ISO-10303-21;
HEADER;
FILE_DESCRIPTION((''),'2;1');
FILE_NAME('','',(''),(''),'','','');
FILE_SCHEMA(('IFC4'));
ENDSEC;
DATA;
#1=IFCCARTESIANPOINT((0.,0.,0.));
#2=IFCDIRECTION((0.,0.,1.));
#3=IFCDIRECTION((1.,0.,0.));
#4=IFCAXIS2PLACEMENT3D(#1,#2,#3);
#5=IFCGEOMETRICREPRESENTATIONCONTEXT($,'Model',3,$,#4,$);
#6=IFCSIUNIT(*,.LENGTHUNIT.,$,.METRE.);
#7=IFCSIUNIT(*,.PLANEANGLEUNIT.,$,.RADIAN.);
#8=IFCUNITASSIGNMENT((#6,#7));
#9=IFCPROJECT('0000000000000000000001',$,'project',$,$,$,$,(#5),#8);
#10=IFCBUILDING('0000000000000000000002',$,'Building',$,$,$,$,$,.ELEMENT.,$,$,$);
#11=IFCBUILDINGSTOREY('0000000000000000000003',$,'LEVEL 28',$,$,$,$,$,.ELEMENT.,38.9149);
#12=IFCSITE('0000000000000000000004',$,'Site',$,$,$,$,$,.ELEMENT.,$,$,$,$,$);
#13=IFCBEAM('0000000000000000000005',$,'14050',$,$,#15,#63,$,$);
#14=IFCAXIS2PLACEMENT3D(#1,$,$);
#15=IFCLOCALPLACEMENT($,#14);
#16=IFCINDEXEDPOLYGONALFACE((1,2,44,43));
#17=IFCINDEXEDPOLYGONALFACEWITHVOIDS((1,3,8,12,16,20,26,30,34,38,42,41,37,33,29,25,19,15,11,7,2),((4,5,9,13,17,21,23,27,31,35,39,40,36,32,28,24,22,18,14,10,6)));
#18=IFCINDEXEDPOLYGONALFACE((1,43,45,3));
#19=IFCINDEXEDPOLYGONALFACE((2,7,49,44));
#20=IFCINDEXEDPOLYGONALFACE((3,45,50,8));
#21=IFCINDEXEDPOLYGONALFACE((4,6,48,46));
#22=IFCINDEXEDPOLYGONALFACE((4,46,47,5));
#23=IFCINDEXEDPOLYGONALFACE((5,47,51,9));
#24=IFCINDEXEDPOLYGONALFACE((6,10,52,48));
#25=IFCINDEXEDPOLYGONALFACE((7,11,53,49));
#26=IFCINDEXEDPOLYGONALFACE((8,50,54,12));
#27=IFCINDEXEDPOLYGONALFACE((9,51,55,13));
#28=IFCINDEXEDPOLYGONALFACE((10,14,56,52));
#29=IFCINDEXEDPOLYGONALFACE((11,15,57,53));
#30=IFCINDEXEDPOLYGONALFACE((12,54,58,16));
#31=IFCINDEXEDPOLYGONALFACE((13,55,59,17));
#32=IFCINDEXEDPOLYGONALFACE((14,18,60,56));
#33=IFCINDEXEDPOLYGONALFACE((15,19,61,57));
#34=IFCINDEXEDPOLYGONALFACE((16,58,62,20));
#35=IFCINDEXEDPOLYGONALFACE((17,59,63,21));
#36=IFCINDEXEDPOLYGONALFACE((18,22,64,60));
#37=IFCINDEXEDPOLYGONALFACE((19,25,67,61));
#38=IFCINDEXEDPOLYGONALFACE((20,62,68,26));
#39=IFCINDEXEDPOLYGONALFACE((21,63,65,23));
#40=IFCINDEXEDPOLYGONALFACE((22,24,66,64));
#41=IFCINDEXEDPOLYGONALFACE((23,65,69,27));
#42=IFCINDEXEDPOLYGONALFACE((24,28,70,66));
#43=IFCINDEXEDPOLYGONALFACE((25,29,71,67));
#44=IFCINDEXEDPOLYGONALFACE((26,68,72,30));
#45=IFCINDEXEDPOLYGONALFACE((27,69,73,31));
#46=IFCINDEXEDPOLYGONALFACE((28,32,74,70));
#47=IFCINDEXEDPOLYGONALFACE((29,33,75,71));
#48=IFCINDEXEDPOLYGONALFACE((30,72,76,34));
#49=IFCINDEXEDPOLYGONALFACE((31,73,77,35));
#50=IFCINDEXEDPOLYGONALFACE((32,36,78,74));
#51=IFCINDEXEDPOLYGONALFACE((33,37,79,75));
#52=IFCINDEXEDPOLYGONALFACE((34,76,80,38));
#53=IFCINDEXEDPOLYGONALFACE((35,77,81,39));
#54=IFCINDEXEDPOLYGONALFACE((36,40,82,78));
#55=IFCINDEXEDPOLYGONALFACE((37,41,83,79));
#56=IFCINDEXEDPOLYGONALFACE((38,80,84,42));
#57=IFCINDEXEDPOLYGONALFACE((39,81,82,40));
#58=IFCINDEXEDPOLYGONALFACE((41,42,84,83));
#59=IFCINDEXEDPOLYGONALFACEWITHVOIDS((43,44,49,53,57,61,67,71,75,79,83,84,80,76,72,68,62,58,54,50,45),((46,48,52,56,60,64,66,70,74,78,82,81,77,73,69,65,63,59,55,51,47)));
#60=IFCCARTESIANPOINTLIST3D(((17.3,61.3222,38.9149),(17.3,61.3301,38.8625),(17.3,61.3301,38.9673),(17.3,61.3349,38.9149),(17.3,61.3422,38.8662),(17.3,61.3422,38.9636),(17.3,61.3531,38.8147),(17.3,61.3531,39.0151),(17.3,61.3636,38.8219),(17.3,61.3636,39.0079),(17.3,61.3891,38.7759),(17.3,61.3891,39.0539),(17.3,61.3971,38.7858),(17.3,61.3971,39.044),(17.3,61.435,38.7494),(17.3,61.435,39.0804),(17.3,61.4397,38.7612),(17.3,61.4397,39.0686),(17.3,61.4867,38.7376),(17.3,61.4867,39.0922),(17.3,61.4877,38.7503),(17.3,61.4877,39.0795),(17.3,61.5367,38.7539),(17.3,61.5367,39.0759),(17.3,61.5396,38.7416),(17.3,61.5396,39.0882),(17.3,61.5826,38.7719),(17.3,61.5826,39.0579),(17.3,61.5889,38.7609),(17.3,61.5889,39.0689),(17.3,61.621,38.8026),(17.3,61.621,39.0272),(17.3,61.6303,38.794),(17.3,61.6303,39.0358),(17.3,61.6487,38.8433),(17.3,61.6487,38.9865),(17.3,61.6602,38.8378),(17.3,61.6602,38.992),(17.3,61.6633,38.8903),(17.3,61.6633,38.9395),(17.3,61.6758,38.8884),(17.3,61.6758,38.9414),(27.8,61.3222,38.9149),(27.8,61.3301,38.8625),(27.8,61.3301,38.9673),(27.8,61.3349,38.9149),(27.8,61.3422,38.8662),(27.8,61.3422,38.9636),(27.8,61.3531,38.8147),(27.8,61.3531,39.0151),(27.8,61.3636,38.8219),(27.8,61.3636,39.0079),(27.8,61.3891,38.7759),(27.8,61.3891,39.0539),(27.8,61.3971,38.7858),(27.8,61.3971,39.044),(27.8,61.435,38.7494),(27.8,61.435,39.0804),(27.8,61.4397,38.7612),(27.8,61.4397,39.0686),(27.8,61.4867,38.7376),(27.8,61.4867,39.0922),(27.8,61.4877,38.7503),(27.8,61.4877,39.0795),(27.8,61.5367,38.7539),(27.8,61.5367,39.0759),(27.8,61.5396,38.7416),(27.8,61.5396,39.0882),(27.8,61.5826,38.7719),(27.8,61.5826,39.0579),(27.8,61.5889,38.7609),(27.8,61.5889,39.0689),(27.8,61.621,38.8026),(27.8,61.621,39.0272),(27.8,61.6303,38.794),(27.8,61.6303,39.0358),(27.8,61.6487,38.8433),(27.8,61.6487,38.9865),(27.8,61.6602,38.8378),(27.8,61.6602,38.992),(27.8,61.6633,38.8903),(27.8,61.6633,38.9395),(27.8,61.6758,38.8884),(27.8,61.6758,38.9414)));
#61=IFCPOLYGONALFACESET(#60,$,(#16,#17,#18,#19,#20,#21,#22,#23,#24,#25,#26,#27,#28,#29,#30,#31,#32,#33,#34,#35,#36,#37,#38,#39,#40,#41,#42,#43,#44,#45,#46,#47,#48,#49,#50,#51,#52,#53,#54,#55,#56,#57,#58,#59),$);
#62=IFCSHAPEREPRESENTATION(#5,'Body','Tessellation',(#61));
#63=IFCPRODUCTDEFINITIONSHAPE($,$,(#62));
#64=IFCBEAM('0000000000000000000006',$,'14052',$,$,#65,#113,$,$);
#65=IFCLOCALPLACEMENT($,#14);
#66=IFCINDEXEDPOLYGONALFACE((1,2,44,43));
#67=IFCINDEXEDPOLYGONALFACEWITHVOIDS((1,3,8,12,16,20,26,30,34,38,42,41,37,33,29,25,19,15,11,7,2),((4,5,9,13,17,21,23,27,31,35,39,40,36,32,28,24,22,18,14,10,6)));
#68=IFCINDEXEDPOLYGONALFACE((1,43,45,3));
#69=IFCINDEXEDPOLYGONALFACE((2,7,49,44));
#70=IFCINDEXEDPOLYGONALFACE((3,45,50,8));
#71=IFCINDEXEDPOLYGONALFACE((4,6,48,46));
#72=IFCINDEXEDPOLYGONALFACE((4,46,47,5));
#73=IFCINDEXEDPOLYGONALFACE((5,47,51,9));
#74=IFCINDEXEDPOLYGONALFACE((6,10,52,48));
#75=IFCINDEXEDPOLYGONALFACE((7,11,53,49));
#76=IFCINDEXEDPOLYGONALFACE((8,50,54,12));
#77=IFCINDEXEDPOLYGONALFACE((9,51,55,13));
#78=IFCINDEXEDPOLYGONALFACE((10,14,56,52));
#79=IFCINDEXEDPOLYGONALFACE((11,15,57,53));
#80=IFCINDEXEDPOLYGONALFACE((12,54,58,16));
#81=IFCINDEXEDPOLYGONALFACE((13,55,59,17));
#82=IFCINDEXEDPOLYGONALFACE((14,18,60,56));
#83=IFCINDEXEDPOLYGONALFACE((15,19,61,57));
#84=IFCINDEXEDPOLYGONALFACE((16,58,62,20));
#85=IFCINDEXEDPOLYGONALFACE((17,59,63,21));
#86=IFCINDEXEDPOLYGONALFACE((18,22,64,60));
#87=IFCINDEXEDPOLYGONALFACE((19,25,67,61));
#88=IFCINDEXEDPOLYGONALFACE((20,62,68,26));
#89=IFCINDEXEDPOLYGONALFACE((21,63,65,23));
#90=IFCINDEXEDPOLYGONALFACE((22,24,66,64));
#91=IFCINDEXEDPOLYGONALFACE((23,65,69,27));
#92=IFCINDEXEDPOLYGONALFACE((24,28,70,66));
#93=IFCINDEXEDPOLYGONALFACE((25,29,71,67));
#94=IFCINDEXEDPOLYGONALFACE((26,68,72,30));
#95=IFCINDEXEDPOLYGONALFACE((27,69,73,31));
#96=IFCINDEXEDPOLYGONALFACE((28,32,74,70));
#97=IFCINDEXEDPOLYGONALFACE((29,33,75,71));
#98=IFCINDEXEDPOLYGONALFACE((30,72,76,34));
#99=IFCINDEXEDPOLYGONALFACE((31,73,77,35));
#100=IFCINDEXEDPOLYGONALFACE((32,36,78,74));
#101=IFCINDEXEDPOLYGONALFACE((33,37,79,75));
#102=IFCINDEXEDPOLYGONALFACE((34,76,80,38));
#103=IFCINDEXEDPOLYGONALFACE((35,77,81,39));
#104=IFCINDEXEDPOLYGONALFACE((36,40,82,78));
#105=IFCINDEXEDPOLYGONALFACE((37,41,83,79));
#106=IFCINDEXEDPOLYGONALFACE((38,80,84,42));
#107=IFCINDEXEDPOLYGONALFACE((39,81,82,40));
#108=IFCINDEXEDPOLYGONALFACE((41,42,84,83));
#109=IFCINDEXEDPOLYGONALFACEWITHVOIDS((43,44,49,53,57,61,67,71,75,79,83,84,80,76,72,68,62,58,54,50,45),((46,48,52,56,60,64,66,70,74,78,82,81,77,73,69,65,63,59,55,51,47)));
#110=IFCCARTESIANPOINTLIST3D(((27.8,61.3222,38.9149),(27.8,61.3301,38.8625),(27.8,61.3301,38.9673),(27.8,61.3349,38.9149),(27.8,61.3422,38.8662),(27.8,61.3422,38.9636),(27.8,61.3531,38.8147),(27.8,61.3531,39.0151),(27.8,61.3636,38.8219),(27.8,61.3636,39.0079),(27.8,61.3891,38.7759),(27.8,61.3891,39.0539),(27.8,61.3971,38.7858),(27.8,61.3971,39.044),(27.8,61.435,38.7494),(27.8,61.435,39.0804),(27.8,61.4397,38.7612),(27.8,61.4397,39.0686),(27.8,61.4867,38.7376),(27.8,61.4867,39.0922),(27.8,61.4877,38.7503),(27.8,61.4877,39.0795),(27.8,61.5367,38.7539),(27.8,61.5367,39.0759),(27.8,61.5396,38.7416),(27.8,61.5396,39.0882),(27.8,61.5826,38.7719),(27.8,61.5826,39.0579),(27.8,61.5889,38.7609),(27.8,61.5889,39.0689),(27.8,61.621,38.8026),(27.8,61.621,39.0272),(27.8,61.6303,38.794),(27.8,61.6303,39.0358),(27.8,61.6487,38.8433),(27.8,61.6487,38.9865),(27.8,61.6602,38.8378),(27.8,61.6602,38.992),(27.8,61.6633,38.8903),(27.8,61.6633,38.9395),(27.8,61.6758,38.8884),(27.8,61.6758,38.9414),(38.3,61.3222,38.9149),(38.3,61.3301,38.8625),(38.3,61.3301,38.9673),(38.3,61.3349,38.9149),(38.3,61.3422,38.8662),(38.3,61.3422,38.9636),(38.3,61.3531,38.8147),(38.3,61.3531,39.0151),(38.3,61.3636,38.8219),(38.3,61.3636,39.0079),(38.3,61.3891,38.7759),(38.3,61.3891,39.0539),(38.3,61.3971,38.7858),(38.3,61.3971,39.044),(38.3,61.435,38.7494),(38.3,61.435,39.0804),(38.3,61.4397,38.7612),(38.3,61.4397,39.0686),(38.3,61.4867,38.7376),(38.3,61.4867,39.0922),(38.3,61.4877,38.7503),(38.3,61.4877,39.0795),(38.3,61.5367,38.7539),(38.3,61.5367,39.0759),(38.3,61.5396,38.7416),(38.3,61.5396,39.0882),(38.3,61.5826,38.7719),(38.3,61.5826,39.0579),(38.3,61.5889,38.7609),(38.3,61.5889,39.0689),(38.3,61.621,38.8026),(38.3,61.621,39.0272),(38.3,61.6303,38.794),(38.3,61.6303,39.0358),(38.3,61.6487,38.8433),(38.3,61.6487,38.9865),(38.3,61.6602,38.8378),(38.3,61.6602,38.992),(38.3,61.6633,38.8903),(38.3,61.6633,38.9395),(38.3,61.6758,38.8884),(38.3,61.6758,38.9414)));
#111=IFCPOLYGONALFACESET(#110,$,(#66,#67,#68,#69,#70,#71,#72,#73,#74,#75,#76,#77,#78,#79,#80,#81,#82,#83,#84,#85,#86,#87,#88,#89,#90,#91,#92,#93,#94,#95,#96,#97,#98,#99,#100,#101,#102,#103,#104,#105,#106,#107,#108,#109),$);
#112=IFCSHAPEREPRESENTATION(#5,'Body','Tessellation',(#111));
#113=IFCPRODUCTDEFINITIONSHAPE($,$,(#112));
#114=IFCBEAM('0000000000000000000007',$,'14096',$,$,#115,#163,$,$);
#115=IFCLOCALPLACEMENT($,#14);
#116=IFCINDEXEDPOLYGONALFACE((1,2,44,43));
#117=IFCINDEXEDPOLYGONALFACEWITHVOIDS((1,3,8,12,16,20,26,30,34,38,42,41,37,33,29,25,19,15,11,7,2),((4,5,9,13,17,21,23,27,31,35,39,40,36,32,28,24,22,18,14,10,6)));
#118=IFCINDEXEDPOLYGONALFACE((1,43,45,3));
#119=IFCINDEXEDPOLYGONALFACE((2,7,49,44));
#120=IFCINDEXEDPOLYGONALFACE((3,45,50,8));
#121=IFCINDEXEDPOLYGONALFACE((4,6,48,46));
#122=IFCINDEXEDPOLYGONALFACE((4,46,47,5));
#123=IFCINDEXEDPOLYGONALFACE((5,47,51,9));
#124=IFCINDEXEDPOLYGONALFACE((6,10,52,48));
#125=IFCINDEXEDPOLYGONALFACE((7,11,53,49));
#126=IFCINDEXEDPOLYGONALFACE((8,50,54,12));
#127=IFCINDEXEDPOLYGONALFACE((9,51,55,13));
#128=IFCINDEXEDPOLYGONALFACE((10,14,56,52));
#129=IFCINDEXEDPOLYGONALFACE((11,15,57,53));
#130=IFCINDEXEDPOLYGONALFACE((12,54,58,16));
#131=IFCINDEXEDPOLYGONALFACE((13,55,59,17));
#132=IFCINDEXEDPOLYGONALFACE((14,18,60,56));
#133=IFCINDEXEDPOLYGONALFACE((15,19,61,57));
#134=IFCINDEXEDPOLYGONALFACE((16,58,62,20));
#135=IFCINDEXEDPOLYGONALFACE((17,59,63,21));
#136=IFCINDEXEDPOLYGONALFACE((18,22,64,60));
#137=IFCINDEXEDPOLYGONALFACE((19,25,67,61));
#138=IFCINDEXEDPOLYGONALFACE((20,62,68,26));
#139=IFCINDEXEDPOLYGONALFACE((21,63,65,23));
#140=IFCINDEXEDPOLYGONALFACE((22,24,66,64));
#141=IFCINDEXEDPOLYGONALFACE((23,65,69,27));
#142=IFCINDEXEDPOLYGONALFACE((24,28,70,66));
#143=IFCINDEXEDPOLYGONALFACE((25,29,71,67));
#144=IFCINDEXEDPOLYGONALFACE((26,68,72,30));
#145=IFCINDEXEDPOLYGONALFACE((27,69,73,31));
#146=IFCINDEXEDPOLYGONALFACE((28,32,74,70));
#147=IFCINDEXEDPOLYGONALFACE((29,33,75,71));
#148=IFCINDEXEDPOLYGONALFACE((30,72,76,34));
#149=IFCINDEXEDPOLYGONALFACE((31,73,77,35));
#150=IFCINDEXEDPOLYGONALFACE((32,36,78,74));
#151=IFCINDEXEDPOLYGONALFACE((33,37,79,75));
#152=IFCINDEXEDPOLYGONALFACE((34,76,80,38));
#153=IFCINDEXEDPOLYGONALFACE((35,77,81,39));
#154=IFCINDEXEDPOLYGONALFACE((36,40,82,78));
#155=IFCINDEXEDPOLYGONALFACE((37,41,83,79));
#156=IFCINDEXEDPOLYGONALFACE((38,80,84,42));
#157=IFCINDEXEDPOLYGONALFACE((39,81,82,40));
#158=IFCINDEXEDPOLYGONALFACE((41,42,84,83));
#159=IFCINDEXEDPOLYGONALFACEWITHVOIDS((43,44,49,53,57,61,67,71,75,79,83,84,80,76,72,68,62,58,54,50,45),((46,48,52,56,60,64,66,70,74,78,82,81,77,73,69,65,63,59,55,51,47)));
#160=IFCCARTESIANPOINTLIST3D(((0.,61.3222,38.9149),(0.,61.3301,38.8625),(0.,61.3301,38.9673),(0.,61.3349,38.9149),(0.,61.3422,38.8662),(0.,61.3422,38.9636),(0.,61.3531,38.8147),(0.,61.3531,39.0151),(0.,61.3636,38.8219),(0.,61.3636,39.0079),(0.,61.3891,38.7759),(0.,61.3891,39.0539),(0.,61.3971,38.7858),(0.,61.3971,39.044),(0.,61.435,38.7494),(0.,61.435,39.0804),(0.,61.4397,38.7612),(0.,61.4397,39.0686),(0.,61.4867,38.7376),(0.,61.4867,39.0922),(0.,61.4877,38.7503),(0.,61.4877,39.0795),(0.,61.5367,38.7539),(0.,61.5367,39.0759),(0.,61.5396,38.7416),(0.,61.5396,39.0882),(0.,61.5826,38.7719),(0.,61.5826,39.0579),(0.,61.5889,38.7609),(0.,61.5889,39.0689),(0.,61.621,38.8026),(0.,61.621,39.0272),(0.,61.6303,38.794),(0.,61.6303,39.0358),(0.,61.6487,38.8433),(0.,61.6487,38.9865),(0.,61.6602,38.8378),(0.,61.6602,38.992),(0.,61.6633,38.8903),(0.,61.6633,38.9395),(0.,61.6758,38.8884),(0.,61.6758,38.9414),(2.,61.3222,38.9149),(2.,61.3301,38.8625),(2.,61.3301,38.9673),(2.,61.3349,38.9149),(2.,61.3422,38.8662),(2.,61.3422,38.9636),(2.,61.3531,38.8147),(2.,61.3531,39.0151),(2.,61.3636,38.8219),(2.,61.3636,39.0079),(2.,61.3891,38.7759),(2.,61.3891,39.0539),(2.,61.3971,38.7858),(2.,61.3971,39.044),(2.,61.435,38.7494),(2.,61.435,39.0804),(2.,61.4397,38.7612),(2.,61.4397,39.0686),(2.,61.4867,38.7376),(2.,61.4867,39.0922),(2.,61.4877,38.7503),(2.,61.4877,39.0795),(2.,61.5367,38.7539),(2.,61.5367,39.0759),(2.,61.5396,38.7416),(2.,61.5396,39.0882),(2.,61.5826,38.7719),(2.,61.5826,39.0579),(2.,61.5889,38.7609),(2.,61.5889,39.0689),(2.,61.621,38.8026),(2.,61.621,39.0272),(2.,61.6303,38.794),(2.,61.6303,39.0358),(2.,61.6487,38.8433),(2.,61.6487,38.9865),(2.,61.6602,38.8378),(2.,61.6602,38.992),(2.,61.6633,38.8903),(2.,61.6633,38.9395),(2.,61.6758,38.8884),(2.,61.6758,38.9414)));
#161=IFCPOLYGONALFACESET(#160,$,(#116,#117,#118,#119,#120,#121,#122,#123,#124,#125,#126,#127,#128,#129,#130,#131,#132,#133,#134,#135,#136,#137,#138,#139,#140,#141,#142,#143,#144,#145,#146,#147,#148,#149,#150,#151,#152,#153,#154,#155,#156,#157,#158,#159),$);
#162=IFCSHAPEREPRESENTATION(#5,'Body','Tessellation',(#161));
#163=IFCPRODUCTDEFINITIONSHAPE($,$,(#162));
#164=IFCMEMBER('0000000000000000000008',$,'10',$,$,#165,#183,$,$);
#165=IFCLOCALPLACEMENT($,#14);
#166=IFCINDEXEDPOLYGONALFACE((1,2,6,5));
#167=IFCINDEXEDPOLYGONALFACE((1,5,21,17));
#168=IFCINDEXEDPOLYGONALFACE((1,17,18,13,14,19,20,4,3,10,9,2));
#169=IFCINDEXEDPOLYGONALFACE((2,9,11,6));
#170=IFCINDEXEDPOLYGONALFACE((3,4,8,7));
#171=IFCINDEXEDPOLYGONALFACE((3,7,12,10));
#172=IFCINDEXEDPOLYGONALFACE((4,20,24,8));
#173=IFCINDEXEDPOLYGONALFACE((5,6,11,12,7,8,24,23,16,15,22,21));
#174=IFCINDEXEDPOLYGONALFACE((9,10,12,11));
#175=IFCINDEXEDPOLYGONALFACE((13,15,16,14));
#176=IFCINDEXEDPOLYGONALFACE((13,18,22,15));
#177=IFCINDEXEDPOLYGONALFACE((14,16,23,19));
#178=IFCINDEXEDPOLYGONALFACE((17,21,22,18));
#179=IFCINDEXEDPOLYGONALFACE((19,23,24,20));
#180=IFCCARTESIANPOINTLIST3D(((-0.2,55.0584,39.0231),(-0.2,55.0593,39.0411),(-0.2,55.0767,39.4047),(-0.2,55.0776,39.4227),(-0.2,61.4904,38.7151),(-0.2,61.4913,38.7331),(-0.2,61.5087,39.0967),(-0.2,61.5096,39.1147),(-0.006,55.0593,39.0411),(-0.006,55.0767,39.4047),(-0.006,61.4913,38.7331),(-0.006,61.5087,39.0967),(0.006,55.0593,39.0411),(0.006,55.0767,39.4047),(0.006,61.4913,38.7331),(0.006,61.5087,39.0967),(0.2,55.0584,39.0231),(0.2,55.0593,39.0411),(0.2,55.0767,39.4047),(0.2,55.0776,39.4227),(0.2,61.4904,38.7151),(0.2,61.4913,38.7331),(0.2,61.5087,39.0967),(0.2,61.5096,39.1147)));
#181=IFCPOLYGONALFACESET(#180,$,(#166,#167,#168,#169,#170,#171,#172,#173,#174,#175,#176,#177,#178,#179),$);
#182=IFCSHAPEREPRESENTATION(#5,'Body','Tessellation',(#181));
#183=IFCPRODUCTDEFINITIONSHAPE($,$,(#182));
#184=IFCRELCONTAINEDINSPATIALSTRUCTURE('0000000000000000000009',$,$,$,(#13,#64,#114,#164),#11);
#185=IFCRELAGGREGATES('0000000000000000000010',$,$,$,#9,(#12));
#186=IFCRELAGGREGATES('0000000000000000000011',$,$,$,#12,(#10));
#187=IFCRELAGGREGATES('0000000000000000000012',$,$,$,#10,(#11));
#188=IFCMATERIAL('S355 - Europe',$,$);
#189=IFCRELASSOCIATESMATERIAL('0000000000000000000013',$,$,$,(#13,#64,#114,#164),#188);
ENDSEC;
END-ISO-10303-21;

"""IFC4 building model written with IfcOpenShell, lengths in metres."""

from ifc_helpers import new_model, si_unit, frame, origin_with_axes, origin_2d_with_axis, place, context, project, spatial, hollow_circle, i_section, extrude, material, material_profile, profile_set, profile_usage, element, save


model = new_model("IFC4")

# Units and contexts
model_context = context("Model", 3, world=origin_with_axes())
ifc_project = project(units=[si_unit("LENGTHUNIT", "METRE"), si_unit("PLANEANGLEUNIT", "RADIAN")], contexts=[model_context])

# Site, building, storey
site = spatial("IfcSite", under=ifc_project, Name="Site", CompositionType="ELEMENT")
building = spatial("IfcBuilding", under=site, Name="Building", CompositionType="ELEMENT")
storey = spatial("IfcBuildingStorey", under=building, Name="LEVEL 28", CompositionType="ELEMENT", Elevation=38.9149)

# Beams
ifc_material = material(Name="S355 - Europe")
ifc_material_profile_1 = material_profile(ifc_material, hollow_circle(Radius=0.1778, WallThickness=0.0127, at=origin_2d_with_axis()))
ifc_profile_set_1 = profile_set([ifc_material_profile_1])
ifc_profile_usage_1 = profile_usage(ifc_profile_set_1, cardinal=10)
beam_1_placement = place(None, frame((27.8, 61.5, 38.9149), z_axis=(-1.0, 0.0, 0.0), x_axis=(0.0, -1.0, 0.0)))
element("IfcBeam", 1, at=beam_1_placement, inside=storey, material=ifc_profile_usage_1, Name="14050", context=model_context, shape_type="SweptSolid", body=[
    extrude(hollow_circle(Radius=0.1778, WallThickness=0.0127, at=origin_2d_with_axis()), origin_with_axes(), (0.0, 0.0, 1.0), 10.5),
])
ifc_material_profile_2 = material_profile(ifc_material, hollow_circle(Radius=0.1778, WallThickness=0.0127, at=origin_2d_with_axis()))
ifc_profile_set_2 = profile_set([ifc_material_profile_2])
ifc_profile_usage_2 = profile_usage(ifc_profile_set_2, cardinal=10)
beam_2_placement = place(None, frame((38.3, 61.5, 38.9149), z_axis=(-1.0, 0.0, 0.0), x_axis=(0.0, -1.0, 0.0)))
element("IfcBeam", 2, at=beam_2_placement, inside=storey, material=ifc_profile_usage_2, Name="14052", context=model_context, shape_type="SweptSolid", body=[
    extrude(hollow_circle(Radius=0.1778, WallThickness=0.0127, at=origin_2d_with_axis()), origin_with_axes(), (0.0, 0.0, 1.0), 10.5),
])
ifc_material_profile_3 = material_profile(ifc_material, hollow_circle(Radius=0.1778, WallThickness=0.0127, at=origin_2d_with_axis()))
ifc_profile_set_3 = profile_set([ifc_material_profile_3])
ifc_profile_usage_3 = profile_usage(ifc_profile_set_3, cardinal=10)
beam_3_placement = place(None, frame((2.0, 61.5, 38.9149), z_axis=(-1.0, 0.0, 0.0), x_axis=(0.0, -1.0, 0.0)))
element("IfcBeam", 3, at=beam_3_placement, inside=storey, material=ifc_profile_usage_3, Name="14096", context=model_context, shape_type="SweptSolid", body=[
    extrude(hollow_circle(Radius=0.1778, WallThickness=0.0127, at=origin_2d_with_axis()), origin_with_axes(), (0.0, 0.0, 1.0), 2.0),
])

# Member
ifc_material_profile_4 = material_profile(ifc_material, i_section(OverallWidth=0.4, OverallDepth=0.4, WebThickness=0.012, FlangeThickness=0.018, at=origin_2d_with_axis()))
ifc_profile_set_4 = profile_set([ifc_material_profile_4])
ifc_profile_usage_4 = profile_usage(ifc_profile_set_4, cardinal=10)
member_1_placement = place(None, frame((0.0, 61.5, 38.9149), z_axis=(0.0, -0.998856, 0.047828), x_axis=(1.0, 0.0, 0.0)))
element("IfcMember", 4, at=member_1_placement, inside=storey, material=ifc_profile_usage_4, Name="10", context=model_context, shape_type="SweptSolid", body=[
    extrude(i_section(OverallWidth=0.4, OverallDepth=0.4, WebThickness=0.012, FlangeThickness=0.018, at=origin_2d_with_axis()), origin_with_axes(), (0.0, 0.0, 1.0), 6.4394),
])

save(model, "model.ifc")
